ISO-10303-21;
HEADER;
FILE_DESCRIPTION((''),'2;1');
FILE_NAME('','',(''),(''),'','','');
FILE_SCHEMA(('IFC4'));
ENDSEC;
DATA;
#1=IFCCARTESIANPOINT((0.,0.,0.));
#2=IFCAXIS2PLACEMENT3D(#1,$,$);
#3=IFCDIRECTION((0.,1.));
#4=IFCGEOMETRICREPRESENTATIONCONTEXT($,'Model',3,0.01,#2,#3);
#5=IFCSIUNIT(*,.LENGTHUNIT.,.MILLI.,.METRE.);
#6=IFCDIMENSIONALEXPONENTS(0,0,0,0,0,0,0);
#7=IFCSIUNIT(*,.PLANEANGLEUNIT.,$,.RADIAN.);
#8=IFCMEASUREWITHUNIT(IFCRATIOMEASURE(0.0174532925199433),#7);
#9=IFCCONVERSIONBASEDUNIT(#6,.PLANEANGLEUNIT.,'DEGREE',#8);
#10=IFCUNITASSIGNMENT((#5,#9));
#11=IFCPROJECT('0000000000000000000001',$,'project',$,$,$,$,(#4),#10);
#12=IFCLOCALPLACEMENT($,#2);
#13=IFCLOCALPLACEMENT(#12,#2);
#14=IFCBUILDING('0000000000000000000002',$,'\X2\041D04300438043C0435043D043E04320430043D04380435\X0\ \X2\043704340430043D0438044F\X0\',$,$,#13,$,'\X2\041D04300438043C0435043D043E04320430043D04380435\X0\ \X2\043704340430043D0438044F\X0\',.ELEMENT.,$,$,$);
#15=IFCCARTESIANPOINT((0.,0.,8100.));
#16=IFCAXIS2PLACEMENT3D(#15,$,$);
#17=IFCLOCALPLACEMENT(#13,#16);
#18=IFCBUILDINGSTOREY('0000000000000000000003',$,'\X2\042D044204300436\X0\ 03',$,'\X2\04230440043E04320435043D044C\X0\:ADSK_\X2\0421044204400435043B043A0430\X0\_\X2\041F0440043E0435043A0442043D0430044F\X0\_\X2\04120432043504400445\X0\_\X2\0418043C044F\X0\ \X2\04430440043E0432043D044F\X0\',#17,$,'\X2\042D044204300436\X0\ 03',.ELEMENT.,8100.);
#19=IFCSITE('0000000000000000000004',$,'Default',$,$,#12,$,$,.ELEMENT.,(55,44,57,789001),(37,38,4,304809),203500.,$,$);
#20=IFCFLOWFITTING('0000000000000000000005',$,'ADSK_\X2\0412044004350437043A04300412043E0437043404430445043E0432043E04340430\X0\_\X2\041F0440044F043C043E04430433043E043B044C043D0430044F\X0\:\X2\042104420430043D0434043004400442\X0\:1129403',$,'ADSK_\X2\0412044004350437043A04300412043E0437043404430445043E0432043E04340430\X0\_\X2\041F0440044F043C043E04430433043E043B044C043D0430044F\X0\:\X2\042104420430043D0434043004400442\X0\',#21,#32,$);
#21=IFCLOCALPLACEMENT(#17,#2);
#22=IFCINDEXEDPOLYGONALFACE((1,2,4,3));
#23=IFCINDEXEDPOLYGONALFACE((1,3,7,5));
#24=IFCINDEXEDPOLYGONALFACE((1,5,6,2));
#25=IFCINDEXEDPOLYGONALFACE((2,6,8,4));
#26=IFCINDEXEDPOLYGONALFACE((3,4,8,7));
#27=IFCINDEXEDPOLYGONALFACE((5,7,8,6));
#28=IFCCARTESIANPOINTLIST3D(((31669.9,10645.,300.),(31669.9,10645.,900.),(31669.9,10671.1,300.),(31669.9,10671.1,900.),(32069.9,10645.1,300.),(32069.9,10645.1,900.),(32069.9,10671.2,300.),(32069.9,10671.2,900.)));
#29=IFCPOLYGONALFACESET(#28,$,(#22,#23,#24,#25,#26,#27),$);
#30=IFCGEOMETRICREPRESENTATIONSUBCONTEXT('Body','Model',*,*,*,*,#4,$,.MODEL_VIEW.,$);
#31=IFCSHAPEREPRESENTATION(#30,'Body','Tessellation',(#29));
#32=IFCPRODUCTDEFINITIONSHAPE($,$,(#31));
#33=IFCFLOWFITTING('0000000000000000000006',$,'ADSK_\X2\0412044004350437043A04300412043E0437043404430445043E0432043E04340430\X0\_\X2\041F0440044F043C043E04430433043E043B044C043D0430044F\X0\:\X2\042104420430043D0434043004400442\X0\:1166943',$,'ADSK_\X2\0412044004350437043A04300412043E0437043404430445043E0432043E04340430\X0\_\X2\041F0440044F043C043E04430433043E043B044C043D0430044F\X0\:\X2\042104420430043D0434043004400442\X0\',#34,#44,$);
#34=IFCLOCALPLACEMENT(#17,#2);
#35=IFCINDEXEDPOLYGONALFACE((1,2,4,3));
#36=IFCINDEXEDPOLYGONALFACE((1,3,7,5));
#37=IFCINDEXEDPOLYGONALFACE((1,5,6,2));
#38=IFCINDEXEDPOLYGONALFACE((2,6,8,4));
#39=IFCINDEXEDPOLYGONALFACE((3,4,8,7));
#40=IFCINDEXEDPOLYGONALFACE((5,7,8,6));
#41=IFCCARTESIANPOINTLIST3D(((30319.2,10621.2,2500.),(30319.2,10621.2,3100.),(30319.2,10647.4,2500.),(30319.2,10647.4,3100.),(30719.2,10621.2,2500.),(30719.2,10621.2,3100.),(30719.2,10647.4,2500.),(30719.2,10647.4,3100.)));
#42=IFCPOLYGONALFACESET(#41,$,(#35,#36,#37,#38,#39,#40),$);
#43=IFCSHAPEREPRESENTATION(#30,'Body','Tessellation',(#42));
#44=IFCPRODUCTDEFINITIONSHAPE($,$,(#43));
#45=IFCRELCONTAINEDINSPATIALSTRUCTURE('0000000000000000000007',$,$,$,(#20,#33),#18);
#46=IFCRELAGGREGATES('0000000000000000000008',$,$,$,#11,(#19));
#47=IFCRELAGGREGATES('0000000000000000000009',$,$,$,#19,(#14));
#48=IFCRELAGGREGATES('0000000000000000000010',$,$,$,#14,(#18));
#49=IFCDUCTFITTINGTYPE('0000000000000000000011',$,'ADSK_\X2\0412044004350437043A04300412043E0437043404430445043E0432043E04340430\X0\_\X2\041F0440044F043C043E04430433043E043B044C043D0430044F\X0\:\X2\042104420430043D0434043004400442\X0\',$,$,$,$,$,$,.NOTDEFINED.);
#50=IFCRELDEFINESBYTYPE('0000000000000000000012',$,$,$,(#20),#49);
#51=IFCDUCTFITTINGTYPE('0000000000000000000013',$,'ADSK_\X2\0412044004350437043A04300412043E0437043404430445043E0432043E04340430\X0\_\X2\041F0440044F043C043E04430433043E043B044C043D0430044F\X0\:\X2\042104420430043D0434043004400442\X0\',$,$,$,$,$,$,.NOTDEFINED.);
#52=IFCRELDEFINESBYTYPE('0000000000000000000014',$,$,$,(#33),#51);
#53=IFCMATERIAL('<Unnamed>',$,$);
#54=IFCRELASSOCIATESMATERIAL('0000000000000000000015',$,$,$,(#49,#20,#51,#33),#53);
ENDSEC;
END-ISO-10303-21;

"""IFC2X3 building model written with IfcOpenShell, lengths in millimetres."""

from ifc_helpers import new_model, entity, si_unit, converted_unit, direction, frame, frame_2d, origin, origin_2d_with_axis, place, context, subcontext, project, spatial, rectangle, extrude, source, transform, mapped, material, type_object, type_shapes, element, save


model = new_model("IFC2X3")

# Units and contexts
model_context = context("Model", 3, precision=0.01, world=origin(), true_north=direction((0.0, 1.0)))
body_context = subcontext(model_context, "Body", "Model", "MODEL_VIEW")
ifc_project = project(units=[si_unit("LENGTHUNIT", "METRE", prefix="MILLI"), converted_unit("PLANEANGLEUNIT", "DEGREE", entity("IfcRatioMeasure", 0.0174532925199433), si_unit("PLANEANGLEUNIT", "RADIAN"), dimensions=[0, 0, 0, 0, 0, 0, 0])], contexts=[model_context])

# Site, building, storey
site_placement = place(None, frame((0.0, 0.0, 0.0)))
site = spatial("IfcSite", under=ifc_project, at=site_placement, Name="Default", CompositionType="ELEMENT", RefLatitude=(55, 44, 57, 789001), RefLongitude=(37, 38, 4, 304809), RefElevation=203500.0)
building_placement = place(site_placement, origin())
building = spatial("IfcBuilding", under=site, at=building_placement, Name="Наименование здания", LongName="Наименование здания", CompositionType="ELEMENT")
storey_placement = place(building_placement, frame((0.0, 0.0, 8100.0)))
storey = spatial("IfcBuildingStorey", under=building, at=storey_placement, Name="Этаж 03", ObjectType="Уровень:ADSK_Стрелка_Проектная_Вверх_Имя уровня", LongName="Этаж 03", CompositionType="ELEMENT", Elevation=8100.0)

# Shared definitions
ifc_material_1 = material(Name="<Unnamed>")

# Flow fittings
duct_fitting_type_1 = type_object("IfcDuctFittingType", Name="ADSK_ВрезкаВоздуховода_Прямоугольная:Стандарт", PredefinedType="NOTDEFINED", material=ifc_material_1)
shared_shape_1 = source(origin(), body_context, "Body", "SweptSolid", [
    extrude(rectangle(XDim=600.0, YDim=26.1, at=origin_2d_with_axis()), frame((7.0, 0.0, -200.0), z_axis=(0.0, 0.0, 1.0), x_axis=(0.0, -1.0, 0.0)), (0.0, 0.0, 1.0), 400.0),
])
type_shapes(duct_fitting_type_1, [shared_shape_1])
flow_fitting_1_placement = place(storey_placement, frame((31869.9, 10665.1, 600.0), z_axis=(-1.0, -0.000236, 0.0), x_axis=(0.000236, -1.0, 0.0)))
element("IfcFlowFitting", 1, at=flow_fitting_1_placement, inside=storey, type_object=duct_fitting_type_1, material=ifc_material_1, Name="ADSK_ВрезкаВоздуховода_Прямоугольная:Стандарт:1129403", ObjectType="ADSK_ВрезкаВоздуховода_Прямоугольная:Стандарт", context=body_context, shape_type="MappedRepresentation", body=[
    mapped(shared_shape_1, transform((0.0, 0.0, 0.0), scale=1.0)),
])
duct_fitting_type_2 = type_object("IfcDuctFittingType", Name="ADSK_ВрезкаВоздуховода_Прямоугольная:Стандарт", PredefinedType="NOTDEFINED", material=ifc_material_1)
shared_shape_2 = source(origin(), body_context, "Body", "SweptSolid", [
    extrude(rectangle(XDim=26.2, YDim=600.0, at=frame_2d((0.0, 0.0), x_axis=(1.0, 0.0))), frame((6.9, 0.0, -200.0)), (0.0, 0.0, 1.0), 400.0),
])
type_shapes(duct_fitting_type_2, [shared_shape_2])
flow_fitting_2_placement = place(storey_placement, frame((30519.2, 10641.2, 2800.0), z_axis=(-1.0, 0.0, 0.0), x_axis=(0.0, -1.0, 0.0)))
element("IfcFlowFitting", 2, at=flow_fitting_2_placement, inside=storey, type_object=duct_fitting_type_2, material=ifc_material_1, Name="ADSK_ВрезкаВоздуховода_Прямоугольная:Стандарт:1166943", ObjectType="ADSK_ВрезкаВоздуховода_Прямоугольная:Стандарт", context=body_context, shape_type="MappedRepresentation", body=[
    mapped(shared_shape_2, transform((0.0, 0.0, 0.0), scale=1.0)),
])

save(model, "model.ifc")
